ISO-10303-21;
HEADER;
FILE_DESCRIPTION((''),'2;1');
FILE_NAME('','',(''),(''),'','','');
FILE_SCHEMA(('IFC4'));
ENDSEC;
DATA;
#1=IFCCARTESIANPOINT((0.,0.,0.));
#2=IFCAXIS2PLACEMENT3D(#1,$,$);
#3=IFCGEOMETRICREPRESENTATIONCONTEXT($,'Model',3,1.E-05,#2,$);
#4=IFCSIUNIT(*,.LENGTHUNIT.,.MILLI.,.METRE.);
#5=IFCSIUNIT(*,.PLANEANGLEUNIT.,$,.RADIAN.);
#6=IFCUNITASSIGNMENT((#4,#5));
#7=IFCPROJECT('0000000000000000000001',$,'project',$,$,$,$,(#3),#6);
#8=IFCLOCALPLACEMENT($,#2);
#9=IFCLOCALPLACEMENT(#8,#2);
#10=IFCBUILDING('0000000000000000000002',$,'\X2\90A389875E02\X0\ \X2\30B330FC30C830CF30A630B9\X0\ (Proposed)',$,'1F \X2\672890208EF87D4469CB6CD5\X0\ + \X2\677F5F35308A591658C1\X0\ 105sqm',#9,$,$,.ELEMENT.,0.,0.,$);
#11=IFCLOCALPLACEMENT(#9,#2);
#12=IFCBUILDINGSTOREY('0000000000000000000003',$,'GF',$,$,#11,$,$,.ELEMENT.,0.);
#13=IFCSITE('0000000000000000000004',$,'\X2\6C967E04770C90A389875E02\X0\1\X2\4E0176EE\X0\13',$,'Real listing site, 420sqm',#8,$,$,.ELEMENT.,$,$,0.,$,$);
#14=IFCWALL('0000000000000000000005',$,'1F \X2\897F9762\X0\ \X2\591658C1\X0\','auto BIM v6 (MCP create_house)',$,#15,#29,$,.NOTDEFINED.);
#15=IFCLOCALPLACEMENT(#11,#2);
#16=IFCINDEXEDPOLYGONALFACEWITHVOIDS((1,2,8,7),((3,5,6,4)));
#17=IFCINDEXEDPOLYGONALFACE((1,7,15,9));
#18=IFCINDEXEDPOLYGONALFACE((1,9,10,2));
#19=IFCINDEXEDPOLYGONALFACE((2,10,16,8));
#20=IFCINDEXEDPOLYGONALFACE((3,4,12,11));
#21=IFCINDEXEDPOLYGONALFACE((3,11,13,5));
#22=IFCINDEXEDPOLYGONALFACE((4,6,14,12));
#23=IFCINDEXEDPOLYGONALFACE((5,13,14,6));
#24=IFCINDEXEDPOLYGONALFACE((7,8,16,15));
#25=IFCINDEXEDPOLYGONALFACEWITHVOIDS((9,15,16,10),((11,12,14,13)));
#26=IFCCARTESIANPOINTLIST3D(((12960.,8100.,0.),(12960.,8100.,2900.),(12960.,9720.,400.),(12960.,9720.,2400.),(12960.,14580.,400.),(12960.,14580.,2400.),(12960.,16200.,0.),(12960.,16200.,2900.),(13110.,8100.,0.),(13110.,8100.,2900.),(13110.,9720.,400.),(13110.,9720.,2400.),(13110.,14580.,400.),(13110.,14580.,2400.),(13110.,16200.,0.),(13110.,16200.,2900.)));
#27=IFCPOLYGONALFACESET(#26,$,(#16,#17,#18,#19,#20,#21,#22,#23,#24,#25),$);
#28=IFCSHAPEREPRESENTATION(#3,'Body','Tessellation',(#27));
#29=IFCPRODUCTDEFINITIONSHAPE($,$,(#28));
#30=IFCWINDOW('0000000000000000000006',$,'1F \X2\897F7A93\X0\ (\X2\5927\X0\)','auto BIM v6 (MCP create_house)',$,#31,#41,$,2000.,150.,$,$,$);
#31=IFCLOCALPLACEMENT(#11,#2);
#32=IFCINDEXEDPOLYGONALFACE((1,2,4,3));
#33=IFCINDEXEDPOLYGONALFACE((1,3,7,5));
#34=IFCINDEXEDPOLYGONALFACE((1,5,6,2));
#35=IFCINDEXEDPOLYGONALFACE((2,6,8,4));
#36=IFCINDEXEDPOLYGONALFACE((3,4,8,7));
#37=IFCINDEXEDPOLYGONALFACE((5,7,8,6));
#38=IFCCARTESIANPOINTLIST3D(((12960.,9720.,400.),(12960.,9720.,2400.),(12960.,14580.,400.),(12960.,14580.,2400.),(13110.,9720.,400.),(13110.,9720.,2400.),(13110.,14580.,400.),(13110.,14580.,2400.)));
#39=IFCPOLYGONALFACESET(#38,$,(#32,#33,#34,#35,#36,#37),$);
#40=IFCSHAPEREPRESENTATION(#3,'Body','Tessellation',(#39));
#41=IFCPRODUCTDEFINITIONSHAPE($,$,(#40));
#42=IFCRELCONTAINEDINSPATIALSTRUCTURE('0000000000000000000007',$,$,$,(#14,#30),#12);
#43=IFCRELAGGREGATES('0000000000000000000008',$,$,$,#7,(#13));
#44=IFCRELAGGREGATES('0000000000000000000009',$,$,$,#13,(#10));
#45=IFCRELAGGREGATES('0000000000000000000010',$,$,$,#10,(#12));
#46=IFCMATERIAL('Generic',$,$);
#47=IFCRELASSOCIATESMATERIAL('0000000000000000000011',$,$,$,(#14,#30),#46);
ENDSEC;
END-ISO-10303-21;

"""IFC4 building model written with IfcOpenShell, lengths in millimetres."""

from ifc_helpers import new_model, si_unit, frame, frame_2d, origin, place, context, project, spatial, rectangle, extrude, material, element, fill, save


model = new_model("IFC4")

# Units and contexts
model_context = context("Model", 3, precision=1e-05, world=origin())
ifc_project = project(units=[si_unit("LENGTHUNIT", "METRE", prefix="MILLI"), si_unit("PLANEANGLEUNIT", "RADIAN")], contexts=[model_context])

# Site, building, storey
site_placement = place(None, origin())
site = spatial("IfcSite", under=ifc_project, at=site_placement, Name="沖縄県那覇市1丁目13", ObjectType="Real listing site, 420sqm", CompositionType="ELEMENT", RefElevation=0.0)
building_placement = place(site_placement, origin())
building = spatial("IfcBuilding", under=site, at=building_placement, Name="那覇市 コートハウス (Proposed)", ObjectType="1F 木造軸組構法 + 板張り外壁 105sqm", CompositionType="ELEMENT", ElevationOfRefHeight=0.0, ElevationOfTerrain=0.0)
storey_placement = place(building_placement, origin())
storey = spatial("IfcBuildingStorey", under=building, at=storey_placement, Name="GF", CompositionType="ELEMENT", Elevation=0.0)

# Shared definitions
ifc_material = material(Name="Generic")

# Wall, opening, window
wall_1_placement = place(storey_placement, frame((6480.0, 4050.0, 0.0)))
wall_1 = element("IfcWall", 1, at=wall_1_placement, inside=storey, material=ifc_material, Name="1F 西面 外壁", Description="auto BIM v6 (MCP create_house)", PredefinedType="NOTDEFINED", context=model_context, shape_type="SweptSolid", body=[
    extrude(rectangle(XDim=150.0, YDim=8100.0, at=frame_2d((75.0, 4050.0))), frame((6480.0, 4050.0, 0.0)), (0.0, 0.0, 1.0), 2900.0),
])
opening_1_placement = place(storey_placement, frame((6480.0, 4860.0, 200.0)))
opening_1 = element("IfcOpeningElement", 2, at=opening_1_placement, cuts=wall_1, PredefinedType="NOTDEFINED", context=model_context, shape_type="SweptSolid", body=[
    extrude(rectangle(XDim=150.0, YDim=4860.0, at=frame_2d((75.0, 2430.0))), frame((6480.0, 4860.0, 200.0)), (0.0, 0.0, 1.0), 2000.0),
])
window_1_placement = place(storey_placement, frame((6480.0, 4860.0, 200.0)))
window_1 = element("IfcWindow", 3, at=window_1_placement, inside=storey, material=ifc_material, Name="1F 西窓 (大)", Description="auto BIM v6 (MCP create_house)", OverallHeight=2000.0, OverallWidth=150.0, context=model_context, shape_type="SweptSolid", body=[
    extrude(rectangle(XDim=150.0, YDim=4860.0, at=frame_2d((75.0, 2430.0))), frame((6480.0, 4860.0, 200.0)), (0.0, 0.0, 1.0), 2000.0),
])
fill(opening_1, window_1)

save(model, "model.ifc")
